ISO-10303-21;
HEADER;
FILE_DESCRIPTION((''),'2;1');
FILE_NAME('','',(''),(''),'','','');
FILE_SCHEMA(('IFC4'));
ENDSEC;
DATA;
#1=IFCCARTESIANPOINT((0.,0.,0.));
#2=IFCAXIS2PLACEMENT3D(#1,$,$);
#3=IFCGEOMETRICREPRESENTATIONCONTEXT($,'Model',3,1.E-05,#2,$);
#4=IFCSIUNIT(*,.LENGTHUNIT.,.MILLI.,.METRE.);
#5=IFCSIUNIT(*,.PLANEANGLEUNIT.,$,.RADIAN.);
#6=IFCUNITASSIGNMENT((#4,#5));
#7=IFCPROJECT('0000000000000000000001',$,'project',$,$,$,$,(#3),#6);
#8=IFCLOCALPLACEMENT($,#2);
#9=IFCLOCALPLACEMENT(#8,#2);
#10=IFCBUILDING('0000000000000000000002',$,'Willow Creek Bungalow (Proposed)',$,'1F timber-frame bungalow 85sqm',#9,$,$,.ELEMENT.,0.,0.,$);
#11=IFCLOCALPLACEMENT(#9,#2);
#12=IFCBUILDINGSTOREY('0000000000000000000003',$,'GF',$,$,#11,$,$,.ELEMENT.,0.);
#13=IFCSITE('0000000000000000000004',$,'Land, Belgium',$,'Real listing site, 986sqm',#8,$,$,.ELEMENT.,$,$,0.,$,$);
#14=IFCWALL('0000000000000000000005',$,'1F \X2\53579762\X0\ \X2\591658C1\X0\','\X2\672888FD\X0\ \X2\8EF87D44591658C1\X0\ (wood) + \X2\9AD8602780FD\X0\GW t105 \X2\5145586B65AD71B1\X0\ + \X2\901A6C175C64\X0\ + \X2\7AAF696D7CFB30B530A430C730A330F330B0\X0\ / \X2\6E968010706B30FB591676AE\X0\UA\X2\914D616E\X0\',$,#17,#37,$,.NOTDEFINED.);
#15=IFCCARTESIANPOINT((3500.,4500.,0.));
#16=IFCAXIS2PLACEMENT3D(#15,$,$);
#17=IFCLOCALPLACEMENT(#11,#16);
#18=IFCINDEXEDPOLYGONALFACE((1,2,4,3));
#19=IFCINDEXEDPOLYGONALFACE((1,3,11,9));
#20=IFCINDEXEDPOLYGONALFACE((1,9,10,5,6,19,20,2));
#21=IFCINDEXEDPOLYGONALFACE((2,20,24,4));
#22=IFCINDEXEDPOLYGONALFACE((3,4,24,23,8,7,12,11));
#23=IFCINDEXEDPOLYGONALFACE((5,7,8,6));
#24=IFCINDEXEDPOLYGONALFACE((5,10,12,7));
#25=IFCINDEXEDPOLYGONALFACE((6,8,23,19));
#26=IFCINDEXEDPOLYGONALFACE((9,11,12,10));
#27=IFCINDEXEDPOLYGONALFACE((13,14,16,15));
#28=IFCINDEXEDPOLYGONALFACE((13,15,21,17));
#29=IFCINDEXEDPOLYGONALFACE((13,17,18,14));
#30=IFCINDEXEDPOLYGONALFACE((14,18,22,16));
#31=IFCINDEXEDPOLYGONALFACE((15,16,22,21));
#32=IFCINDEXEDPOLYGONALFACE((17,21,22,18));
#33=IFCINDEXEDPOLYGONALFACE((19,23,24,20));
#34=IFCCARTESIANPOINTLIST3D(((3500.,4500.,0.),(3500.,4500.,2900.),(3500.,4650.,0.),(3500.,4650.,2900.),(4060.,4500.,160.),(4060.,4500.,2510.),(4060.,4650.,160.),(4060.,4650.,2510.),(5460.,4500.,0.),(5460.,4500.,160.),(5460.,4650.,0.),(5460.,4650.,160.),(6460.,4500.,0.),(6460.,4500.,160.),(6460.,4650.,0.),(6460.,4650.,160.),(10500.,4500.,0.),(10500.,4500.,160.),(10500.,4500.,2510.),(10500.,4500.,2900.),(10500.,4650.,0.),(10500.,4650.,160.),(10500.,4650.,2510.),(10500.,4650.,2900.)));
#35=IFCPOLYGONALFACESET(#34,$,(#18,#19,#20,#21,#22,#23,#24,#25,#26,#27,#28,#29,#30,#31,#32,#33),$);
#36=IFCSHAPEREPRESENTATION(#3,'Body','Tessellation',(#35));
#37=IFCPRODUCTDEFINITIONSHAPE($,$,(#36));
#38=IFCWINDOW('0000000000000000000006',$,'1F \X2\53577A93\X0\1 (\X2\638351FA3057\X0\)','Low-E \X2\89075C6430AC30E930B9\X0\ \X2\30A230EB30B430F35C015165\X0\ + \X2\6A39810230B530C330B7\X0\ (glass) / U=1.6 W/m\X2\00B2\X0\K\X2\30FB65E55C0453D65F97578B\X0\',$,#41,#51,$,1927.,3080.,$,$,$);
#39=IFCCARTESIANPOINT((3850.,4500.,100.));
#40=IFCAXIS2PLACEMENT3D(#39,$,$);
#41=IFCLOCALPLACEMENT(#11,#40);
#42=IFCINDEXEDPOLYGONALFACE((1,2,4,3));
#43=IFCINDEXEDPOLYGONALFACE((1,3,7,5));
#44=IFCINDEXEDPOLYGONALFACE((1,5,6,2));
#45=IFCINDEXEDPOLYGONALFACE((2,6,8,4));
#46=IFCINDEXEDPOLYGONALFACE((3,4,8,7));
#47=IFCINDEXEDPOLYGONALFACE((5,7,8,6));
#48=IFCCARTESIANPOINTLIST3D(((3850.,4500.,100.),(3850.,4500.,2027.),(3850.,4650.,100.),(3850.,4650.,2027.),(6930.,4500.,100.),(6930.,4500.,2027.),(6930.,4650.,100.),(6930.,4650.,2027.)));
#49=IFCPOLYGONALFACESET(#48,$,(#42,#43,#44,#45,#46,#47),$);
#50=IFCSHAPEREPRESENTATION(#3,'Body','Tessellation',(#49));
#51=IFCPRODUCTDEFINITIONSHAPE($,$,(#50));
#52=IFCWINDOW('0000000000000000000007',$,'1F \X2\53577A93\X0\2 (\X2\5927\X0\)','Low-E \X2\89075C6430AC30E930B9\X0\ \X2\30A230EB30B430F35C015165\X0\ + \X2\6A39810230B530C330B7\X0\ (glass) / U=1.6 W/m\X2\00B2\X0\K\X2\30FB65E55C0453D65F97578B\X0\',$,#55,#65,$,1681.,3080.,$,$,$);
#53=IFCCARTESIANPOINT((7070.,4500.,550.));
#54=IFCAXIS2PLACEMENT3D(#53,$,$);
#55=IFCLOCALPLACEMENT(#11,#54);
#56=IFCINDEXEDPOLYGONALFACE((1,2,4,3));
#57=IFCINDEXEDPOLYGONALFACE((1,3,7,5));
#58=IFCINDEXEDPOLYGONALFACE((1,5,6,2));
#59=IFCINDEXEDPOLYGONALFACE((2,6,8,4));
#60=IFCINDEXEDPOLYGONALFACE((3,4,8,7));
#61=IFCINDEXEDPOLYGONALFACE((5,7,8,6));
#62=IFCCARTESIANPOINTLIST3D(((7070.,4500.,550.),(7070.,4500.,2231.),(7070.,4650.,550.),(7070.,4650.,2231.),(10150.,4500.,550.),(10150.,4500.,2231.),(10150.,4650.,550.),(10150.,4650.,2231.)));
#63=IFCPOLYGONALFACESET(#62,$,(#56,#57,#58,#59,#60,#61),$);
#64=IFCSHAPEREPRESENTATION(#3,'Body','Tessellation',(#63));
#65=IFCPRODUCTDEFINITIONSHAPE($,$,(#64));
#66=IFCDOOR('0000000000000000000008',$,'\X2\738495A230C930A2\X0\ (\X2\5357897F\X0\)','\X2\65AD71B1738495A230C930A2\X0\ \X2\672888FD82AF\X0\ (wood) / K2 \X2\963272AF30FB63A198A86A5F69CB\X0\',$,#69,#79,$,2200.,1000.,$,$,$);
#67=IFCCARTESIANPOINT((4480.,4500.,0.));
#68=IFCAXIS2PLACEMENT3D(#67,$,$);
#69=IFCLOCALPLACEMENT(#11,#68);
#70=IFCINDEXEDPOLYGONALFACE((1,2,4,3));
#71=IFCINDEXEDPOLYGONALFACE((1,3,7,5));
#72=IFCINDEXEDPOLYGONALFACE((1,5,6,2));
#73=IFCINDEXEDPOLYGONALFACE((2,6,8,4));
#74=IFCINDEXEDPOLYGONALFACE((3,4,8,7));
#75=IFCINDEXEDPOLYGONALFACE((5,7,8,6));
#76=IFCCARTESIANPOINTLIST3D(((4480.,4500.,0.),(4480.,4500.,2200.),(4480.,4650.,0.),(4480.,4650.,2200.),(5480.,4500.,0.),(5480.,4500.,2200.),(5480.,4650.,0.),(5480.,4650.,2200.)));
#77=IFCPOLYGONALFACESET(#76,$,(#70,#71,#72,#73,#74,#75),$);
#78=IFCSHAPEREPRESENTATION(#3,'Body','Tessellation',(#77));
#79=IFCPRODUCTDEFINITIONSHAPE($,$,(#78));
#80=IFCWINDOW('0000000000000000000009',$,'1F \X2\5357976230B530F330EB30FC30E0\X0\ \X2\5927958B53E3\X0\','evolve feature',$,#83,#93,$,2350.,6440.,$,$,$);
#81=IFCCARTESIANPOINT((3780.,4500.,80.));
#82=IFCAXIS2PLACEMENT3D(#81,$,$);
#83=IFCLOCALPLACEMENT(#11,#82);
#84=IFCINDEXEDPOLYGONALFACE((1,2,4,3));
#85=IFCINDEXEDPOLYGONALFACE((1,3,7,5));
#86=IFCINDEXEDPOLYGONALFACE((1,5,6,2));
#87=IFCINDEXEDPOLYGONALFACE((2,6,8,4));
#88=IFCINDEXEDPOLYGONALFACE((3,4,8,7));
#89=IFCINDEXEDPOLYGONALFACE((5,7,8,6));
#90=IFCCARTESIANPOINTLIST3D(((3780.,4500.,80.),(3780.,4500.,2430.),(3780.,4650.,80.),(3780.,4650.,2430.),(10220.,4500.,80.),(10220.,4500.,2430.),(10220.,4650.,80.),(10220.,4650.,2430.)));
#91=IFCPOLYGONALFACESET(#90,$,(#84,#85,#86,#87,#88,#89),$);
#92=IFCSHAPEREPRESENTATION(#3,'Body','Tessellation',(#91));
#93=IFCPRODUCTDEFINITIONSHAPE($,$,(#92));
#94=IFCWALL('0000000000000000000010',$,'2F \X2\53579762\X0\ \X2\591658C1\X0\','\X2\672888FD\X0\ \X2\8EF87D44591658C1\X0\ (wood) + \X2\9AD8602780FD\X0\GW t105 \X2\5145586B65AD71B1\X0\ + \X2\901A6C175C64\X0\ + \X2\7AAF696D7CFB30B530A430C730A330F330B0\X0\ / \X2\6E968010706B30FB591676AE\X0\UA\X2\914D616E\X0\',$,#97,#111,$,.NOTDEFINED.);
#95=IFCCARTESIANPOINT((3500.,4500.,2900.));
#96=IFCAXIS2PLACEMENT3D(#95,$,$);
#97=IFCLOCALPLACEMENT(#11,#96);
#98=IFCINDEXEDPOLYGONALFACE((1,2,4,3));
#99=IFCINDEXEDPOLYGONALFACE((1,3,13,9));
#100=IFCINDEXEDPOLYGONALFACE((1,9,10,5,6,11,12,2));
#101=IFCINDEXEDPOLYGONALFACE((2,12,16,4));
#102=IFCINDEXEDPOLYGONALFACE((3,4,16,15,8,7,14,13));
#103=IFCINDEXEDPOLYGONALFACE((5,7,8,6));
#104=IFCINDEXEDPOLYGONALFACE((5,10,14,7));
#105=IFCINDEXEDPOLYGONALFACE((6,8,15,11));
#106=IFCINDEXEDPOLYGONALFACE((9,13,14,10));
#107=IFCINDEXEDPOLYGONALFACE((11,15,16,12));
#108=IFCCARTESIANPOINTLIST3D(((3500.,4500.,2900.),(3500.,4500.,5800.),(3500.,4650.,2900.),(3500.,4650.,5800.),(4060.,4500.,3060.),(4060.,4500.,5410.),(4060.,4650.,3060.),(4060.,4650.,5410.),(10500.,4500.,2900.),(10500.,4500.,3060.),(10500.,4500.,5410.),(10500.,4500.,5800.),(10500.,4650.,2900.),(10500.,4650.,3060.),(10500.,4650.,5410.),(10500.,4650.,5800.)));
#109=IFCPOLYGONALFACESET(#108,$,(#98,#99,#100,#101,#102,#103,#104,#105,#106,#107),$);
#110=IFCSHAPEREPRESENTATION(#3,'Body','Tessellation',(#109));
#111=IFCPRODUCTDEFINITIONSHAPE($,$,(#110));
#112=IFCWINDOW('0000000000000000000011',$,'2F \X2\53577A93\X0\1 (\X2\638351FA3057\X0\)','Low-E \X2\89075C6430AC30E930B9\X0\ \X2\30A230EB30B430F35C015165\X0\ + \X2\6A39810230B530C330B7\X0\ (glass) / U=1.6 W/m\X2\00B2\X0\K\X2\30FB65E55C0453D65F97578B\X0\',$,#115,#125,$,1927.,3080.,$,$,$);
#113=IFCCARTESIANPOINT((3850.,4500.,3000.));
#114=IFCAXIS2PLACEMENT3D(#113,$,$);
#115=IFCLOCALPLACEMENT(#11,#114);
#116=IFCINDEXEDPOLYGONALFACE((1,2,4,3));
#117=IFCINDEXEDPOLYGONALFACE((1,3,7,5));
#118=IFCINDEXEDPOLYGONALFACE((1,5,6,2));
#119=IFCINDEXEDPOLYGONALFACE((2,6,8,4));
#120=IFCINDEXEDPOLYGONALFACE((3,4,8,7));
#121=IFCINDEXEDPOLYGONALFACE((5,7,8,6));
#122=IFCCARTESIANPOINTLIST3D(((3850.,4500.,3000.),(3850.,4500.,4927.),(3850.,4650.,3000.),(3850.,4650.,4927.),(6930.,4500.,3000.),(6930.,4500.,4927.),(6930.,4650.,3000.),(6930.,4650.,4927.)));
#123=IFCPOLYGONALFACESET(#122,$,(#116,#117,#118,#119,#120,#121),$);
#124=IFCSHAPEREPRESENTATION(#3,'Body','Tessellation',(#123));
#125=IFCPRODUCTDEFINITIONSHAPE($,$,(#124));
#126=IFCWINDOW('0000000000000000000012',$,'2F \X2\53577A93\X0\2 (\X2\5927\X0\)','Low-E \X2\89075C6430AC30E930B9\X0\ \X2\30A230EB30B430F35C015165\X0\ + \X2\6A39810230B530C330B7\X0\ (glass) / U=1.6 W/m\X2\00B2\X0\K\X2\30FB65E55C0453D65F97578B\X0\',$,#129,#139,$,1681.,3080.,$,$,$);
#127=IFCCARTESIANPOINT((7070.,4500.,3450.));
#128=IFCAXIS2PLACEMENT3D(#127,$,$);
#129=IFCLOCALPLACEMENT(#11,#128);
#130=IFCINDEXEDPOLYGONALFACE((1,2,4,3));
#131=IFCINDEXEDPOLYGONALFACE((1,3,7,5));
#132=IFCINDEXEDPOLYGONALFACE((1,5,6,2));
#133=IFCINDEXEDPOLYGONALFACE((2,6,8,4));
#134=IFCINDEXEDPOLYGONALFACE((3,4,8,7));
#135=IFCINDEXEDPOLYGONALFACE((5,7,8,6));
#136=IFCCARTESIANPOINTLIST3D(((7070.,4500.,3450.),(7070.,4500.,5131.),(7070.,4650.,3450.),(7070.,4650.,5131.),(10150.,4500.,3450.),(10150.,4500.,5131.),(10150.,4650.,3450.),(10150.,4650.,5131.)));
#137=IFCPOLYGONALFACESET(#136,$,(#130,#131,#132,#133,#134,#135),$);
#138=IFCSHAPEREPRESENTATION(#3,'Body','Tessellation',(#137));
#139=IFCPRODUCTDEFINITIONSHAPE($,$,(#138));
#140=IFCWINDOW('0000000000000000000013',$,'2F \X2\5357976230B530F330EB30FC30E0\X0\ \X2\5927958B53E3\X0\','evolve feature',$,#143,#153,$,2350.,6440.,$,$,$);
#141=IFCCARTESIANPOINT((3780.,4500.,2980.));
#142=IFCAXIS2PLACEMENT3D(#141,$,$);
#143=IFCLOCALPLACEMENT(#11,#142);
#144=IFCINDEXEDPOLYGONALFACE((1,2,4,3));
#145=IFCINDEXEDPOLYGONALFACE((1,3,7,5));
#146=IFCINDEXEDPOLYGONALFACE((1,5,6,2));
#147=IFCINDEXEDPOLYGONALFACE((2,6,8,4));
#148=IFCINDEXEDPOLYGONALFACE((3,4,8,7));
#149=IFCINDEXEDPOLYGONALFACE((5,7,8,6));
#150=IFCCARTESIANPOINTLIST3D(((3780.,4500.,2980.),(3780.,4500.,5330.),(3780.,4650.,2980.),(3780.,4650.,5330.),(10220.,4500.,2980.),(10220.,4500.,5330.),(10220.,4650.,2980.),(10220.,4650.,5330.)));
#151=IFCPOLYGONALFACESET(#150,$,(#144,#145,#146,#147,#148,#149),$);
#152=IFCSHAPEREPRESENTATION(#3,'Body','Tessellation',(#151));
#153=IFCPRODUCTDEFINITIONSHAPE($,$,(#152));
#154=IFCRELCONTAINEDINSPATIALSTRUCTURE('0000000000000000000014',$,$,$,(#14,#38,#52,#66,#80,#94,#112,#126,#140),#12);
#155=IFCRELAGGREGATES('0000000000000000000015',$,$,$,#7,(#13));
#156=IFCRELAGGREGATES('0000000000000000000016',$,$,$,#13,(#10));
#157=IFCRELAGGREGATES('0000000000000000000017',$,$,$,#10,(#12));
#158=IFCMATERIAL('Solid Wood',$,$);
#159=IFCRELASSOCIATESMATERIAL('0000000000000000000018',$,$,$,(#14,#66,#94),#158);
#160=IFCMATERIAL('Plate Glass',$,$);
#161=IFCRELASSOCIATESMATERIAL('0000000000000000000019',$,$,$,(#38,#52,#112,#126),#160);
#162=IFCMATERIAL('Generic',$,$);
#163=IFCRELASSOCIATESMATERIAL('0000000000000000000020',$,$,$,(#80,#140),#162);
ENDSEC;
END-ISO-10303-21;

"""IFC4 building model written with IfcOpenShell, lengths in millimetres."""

from ifc_helpers import new_model, si_unit, frame, frame_2d, origin, place, context, project, spatial, rectangle, extrude, material, element, fill, save


model = new_model("IFC4")

# Units and contexts
model_context = context("Model", 3, precision=1e-05, world=origin())
ifc_project = project(units=[si_unit("LENGTHUNIT", "METRE", prefix="MILLI"), si_unit("PLANEANGLEUNIT", "RADIAN")], contexts=[model_context])

# Site, building, storey
site_placement = place(None, origin())
site = spatial("IfcSite", under=ifc_project, at=site_placement, Name="Land, Belgium", ObjectType="Real listing site, 986sqm", CompositionType="ELEMENT", RefElevation=0.0)
building_placement = place(site_placement, origin())
building = spatial("IfcBuilding", under=site, at=building_placement, Name="Willow Creek Bungalow (Proposed)", ObjectType="1F timber-frame bungalow 85sqm", CompositionType="ELEMENT", ElevationOfRefHeight=0.0, ElevationOfTerrain=0.0)
storey_placement = place(building_placement, origin())
storey = spatial("IfcBuildingStorey", under=building, at=storey_placement, Name="GF", CompositionType="ELEMENT", Elevation=0.0)

# Shared definitions
ifc_material_1 = material(Name="Solid Wood")
ifc_material_2 = material(Name="Generic")

# Wall, openings, windows, door
wall_1_placement = place(storey_placement, frame((3500.0, 4500.0, 0.0)))
wall_1 = element("IfcWall", 1, at=wall_1_placement, inside=storey, material=ifc_material_1, Name="1F 南面 外壁", Description="木製 軸組外壁 (wood) + 高性能GW t105 充填断熱 + 通気層 + 窯業系サイディング / 準耐火・外皮UA配慮", PredefinedType="NOTDEFINED", context=model_context, shape_type="SweptSolid", body=[
    extrude(rectangle(XDim=7000.0, YDim=150.0, at=frame_2d((3500.0, 75.0))), frame((3500.0, 4500.0, 0.0)), (0.0, 0.0, 1.0), 2900.0),
])
opening_1_placement = place(storey_placement, frame((3850.0, 4500.0, 100.0)))
opening_1 = element("IfcOpeningElement", 2, at=opening_1_placement, cuts=wall_1, PredefinedType="NOTDEFINED", context=model_context, shape_type="SweptSolid", body=[
    extrude(rectangle(XDim=3080.0, YDim=150.0, at=frame_2d((1540.0, 75.0))), frame((3850.0, 4500.0, 100.0)), (0.0, 0.0, 1.0), 1927.0),
])
opening_2_placement = place(storey_placement, frame((7070.0, 4500.0, 550.0)))
opening_2 = element("IfcOpeningElement", 3, at=opening_2_placement, cuts=wall_1, PredefinedType="NOTDEFINED", context=model_context, shape_type="SweptSolid", body=[
    extrude(rectangle(XDim=3080.0, YDim=150.0, at=frame_2d((1540.0, 75.0))), frame((7070.0, 4500.0, 550.0)), (0.0, 0.0, 1.0), 1681.0),
])
opening_3_placement = place(storey_placement, frame((4480.0, 4500.0, 0.0)))
opening_3 = element("IfcOpeningElement", 4, at=opening_3_placement, cuts=wall_1, PredefinedType="NOTDEFINED", context=model_context, shape_type="SweptSolid", body=[
    extrude(rectangle(XDim=1000.0, YDim=150.0, at=frame_2d((500.0, 75.0))), frame((4480.0, 4500.0, 0.0)), (0.0, 0.0, 1.0), 2200.0),
])
opening_4_placement = place(storey_placement, frame((3780.0, 4500.0, 80.0)))
opening_4 = element("IfcOpeningElement", 5, at=opening_4_placement, cuts=wall_1, PredefinedType="NOTDEFINED", context=model_context, shape_type="SweptSolid", body=[
    extrude(rectangle(XDim=6440.0, YDim=150.0, at=frame_2d((3220.0, 75.0))), frame((3780.0, 4500.0, 80.0)), (0.0, 0.0, 1.0), 2350.0),
])
ifc_material_3 = material(Name="Plate Glass")
window_1_placement = place(storey_placement, frame((3850.0, 4500.0, 100.0)))
window_1 = element("IfcWindow", 6, at=window_1_placement, inside=storey, material=ifc_material_3, Name="1F 南窓1 (掃出し)", Description="Low-E 複層ガラス アルゴン封入 + 樹脂サッシ (glass) / U=1.6 W/m²K・日射取得型", OverallHeight=1927.0, OverallWidth=3080.0, context=model_context, shape_type="SweptSolid", body=[
    extrude(rectangle(XDim=3080.0, YDim=150.0, at=frame_2d((1540.0, 75.0))), frame((3850.0, 4500.0, 100.0)), (0.0, 0.0, 1.0), 1927.0),
])
fill(opening_1, window_1)
window_2_placement = place(storey_placement, frame((7070.0, 4500.0, 550.0)))
window_2 = element("IfcWindow", 7, at=window_2_placement, inside=storey, material=ifc_material_3, Name="1F 南窓2 (大)", Description="Low-E 複層ガラス アルゴン封入 + 樹脂サッシ (glass) / U=1.6 W/m²K・日射取得型", OverallHeight=1681.0, OverallWidth=3080.0, context=model_context, shape_type="SweptSolid", body=[
    extrude(rectangle(XDim=3080.0, YDim=150.0, at=frame_2d((1540.0, 75.0))), frame((7070.0, 4500.0, 550.0)), (0.0, 0.0, 1.0), 1681.0),
])
fill(opening_2, window_2)
door_placement = place(storey_placement, frame((4480.0, 4500.0, 0.0)))
door = element("IfcDoor", 8, at=door_placement, inside=storey, material=ifc_material_1, Name="玄関ドア (南西)", Description="断熱玄関ドア 木製芯 (wood) / K2 防犯・採風機構", OverallHeight=2200.0, OverallWidth=1000.0, context=model_context, shape_type="SweptSolid", body=[
    extrude(rectangle(XDim=1000.0, YDim=150.0, at=frame_2d((500.0, 75.0))), frame((4480.0, 4500.0, 0.0)), (0.0, 0.0, 1.0), 2200.0),
])
fill(opening_3, door)
window_3_placement = place(storey_placement, frame((3780.0, 4500.0, 80.0)))
window_3 = element("IfcWindow", 9, at=window_3_placement, inside=storey, material=ifc_material_2, Name="1F 南面サンルーム 大開口", Description="evolve feature", OverallHeight=2350.0, OverallWidth=6440.0, context=model_context, shape_type="SweptSolid", body=[
    extrude(rectangle(XDim=6440.0, YDim=150.0, at=frame_2d((3220.0, 75.0))), frame((3780.0, 4500.0, 80.0)), (0.0, 0.0, 1.0), 2350.0),
])
fill(opening_4, window_3)

# Wall, openings, windows
wall_2_placement = place(storey_placement, frame((3500.0, 4500.0, 2900.0)))
wall_2 = element("IfcWall", 10, at=wall_2_placement, inside=storey, material=ifc_material_1, Name="2F 南面 外壁", Description="木製 軸組外壁 (wood) + 高性能GW t105 充填断熱 + 通気層 + 窯業系サイディング / 準耐火・外皮UA配慮", PredefinedType="NOTDEFINED", context=model_context, shape_type="SweptSolid", body=[
    extrude(rectangle(XDim=7000.0, YDim=150.0, at=frame_2d((3500.0, 75.0))), frame((3500.0, 4500.0, 2900.0)), (0.0, 0.0, 1.0), 2900.0),
])
opening_5_placement = place(storey_placement, frame((3850.0, 4500.0, 3000.0)))
opening_5 = element("IfcOpeningElement", 11, at=opening_5_placement, cuts=wall_2, PredefinedType="NOTDEFINED", context=model_context, shape_type="SweptSolid", body=[
    extrude(rectangle(XDim=3080.0, YDim=150.0, at=frame_2d((1540.0, 75.0))), frame((3850.0, 4500.0, 3000.0)), (0.0, 0.0, 1.0), 1927.0),
])
opening_6_placement = place(storey_placement, frame((7070.0, 4500.0, 3450.0)))
opening_6 = element("IfcOpeningElement", 12, at=opening_6_placement, cuts=wall_2, PredefinedType="NOTDEFINED", context=model_context, shape_type="SweptSolid", body=[
    extrude(rectangle(XDim=3080.0, YDim=150.0, at=frame_2d((1540.0, 75.0))), frame((7070.0, 4500.0, 3450.0)), (0.0, 0.0, 1.0), 1681.0),
])
opening_7_placement = place(storey_placement, frame((3780.0, 4500.0, 2980.0)))
opening_7 = element("IfcOpeningElement", 13, at=opening_7_placement, cuts=wall_2, PredefinedType="NOTDEFINED", context=model_context, shape_type="SweptSolid", body=[
    extrude(rectangle(XDim=6440.0, YDim=150.0, at=frame_2d((3220.0, 75.0))), frame((3780.0, 4500.0, 2980.0)), (0.0, 0.0, 1.0), 2350.0),
])
window_4_placement = place(storey_placement, frame((3850.0, 4500.0, 3000.0)))
window_4 = element("IfcWindow", 14, at=window_4_placement, inside=storey, material=ifc_material_3, Name="2F 南窓1 (掃出し)", Description="Low-E 複層ガラス アルゴン封入 + 樹脂サッシ (glass) / U=1.6 W/m²K・日射取得型", OverallHeight=1927.0, OverallWidth=3080.0, context=model_context, shape_type="SweptSolid", body=[
    extrude(rectangle(XDim=3080.0, YDim=150.0, at=frame_2d((1540.0, 75.0))), frame((3850.0, 4500.0, 3000.0)), (0.0, 0.0, 1.0), 1927.0),
])
fill(opening_5, window_4)
window_5_placement = place(storey_placement, frame((7070.0, 4500.0, 3450.0)))
window_5 = element("IfcWindow", 15, at=window_5_placement, inside=storey, material=ifc_material_3, Name="2F 南窓2 (大)", Description="Low-E 複層ガラス アルゴン封入 + 樹脂サッシ (glass) / U=1.6 W/m²K・日射取得型", OverallHeight=1681.0, OverallWidth=3080.0, context=model_context, shape_type="SweptSolid", body=[
    extrude(rectangle(XDim=3080.0, YDim=150.0, at=frame_2d((1540.0, 75.0))), frame((7070.0, 4500.0, 3450.0)), (0.0, 0.0, 1.0), 1681.0),
])
fill(opening_6, window_5)
window_6_placement = place(storey_placement, frame((3780.0, 4500.0, 2980.0)))
window_6 = element("IfcWindow", 16, at=window_6_placement, inside=storey, material=ifc_material_2, Name="2F 南面サンルーム 大開口", Description="evolve feature", OverallHeight=2350.0, OverallWidth=6440.0, context=model_context, shape_type="SweptSolid", body=[
    extrude(rectangle(XDim=6440.0, YDim=150.0, at=frame_2d((3220.0, 75.0))), frame((3780.0, 4500.0, 2980.0)), (0.0, 0.0, 1.0), 2350.0),
])
fill(opening_7, window_6)

save(model, "model.ifc")
